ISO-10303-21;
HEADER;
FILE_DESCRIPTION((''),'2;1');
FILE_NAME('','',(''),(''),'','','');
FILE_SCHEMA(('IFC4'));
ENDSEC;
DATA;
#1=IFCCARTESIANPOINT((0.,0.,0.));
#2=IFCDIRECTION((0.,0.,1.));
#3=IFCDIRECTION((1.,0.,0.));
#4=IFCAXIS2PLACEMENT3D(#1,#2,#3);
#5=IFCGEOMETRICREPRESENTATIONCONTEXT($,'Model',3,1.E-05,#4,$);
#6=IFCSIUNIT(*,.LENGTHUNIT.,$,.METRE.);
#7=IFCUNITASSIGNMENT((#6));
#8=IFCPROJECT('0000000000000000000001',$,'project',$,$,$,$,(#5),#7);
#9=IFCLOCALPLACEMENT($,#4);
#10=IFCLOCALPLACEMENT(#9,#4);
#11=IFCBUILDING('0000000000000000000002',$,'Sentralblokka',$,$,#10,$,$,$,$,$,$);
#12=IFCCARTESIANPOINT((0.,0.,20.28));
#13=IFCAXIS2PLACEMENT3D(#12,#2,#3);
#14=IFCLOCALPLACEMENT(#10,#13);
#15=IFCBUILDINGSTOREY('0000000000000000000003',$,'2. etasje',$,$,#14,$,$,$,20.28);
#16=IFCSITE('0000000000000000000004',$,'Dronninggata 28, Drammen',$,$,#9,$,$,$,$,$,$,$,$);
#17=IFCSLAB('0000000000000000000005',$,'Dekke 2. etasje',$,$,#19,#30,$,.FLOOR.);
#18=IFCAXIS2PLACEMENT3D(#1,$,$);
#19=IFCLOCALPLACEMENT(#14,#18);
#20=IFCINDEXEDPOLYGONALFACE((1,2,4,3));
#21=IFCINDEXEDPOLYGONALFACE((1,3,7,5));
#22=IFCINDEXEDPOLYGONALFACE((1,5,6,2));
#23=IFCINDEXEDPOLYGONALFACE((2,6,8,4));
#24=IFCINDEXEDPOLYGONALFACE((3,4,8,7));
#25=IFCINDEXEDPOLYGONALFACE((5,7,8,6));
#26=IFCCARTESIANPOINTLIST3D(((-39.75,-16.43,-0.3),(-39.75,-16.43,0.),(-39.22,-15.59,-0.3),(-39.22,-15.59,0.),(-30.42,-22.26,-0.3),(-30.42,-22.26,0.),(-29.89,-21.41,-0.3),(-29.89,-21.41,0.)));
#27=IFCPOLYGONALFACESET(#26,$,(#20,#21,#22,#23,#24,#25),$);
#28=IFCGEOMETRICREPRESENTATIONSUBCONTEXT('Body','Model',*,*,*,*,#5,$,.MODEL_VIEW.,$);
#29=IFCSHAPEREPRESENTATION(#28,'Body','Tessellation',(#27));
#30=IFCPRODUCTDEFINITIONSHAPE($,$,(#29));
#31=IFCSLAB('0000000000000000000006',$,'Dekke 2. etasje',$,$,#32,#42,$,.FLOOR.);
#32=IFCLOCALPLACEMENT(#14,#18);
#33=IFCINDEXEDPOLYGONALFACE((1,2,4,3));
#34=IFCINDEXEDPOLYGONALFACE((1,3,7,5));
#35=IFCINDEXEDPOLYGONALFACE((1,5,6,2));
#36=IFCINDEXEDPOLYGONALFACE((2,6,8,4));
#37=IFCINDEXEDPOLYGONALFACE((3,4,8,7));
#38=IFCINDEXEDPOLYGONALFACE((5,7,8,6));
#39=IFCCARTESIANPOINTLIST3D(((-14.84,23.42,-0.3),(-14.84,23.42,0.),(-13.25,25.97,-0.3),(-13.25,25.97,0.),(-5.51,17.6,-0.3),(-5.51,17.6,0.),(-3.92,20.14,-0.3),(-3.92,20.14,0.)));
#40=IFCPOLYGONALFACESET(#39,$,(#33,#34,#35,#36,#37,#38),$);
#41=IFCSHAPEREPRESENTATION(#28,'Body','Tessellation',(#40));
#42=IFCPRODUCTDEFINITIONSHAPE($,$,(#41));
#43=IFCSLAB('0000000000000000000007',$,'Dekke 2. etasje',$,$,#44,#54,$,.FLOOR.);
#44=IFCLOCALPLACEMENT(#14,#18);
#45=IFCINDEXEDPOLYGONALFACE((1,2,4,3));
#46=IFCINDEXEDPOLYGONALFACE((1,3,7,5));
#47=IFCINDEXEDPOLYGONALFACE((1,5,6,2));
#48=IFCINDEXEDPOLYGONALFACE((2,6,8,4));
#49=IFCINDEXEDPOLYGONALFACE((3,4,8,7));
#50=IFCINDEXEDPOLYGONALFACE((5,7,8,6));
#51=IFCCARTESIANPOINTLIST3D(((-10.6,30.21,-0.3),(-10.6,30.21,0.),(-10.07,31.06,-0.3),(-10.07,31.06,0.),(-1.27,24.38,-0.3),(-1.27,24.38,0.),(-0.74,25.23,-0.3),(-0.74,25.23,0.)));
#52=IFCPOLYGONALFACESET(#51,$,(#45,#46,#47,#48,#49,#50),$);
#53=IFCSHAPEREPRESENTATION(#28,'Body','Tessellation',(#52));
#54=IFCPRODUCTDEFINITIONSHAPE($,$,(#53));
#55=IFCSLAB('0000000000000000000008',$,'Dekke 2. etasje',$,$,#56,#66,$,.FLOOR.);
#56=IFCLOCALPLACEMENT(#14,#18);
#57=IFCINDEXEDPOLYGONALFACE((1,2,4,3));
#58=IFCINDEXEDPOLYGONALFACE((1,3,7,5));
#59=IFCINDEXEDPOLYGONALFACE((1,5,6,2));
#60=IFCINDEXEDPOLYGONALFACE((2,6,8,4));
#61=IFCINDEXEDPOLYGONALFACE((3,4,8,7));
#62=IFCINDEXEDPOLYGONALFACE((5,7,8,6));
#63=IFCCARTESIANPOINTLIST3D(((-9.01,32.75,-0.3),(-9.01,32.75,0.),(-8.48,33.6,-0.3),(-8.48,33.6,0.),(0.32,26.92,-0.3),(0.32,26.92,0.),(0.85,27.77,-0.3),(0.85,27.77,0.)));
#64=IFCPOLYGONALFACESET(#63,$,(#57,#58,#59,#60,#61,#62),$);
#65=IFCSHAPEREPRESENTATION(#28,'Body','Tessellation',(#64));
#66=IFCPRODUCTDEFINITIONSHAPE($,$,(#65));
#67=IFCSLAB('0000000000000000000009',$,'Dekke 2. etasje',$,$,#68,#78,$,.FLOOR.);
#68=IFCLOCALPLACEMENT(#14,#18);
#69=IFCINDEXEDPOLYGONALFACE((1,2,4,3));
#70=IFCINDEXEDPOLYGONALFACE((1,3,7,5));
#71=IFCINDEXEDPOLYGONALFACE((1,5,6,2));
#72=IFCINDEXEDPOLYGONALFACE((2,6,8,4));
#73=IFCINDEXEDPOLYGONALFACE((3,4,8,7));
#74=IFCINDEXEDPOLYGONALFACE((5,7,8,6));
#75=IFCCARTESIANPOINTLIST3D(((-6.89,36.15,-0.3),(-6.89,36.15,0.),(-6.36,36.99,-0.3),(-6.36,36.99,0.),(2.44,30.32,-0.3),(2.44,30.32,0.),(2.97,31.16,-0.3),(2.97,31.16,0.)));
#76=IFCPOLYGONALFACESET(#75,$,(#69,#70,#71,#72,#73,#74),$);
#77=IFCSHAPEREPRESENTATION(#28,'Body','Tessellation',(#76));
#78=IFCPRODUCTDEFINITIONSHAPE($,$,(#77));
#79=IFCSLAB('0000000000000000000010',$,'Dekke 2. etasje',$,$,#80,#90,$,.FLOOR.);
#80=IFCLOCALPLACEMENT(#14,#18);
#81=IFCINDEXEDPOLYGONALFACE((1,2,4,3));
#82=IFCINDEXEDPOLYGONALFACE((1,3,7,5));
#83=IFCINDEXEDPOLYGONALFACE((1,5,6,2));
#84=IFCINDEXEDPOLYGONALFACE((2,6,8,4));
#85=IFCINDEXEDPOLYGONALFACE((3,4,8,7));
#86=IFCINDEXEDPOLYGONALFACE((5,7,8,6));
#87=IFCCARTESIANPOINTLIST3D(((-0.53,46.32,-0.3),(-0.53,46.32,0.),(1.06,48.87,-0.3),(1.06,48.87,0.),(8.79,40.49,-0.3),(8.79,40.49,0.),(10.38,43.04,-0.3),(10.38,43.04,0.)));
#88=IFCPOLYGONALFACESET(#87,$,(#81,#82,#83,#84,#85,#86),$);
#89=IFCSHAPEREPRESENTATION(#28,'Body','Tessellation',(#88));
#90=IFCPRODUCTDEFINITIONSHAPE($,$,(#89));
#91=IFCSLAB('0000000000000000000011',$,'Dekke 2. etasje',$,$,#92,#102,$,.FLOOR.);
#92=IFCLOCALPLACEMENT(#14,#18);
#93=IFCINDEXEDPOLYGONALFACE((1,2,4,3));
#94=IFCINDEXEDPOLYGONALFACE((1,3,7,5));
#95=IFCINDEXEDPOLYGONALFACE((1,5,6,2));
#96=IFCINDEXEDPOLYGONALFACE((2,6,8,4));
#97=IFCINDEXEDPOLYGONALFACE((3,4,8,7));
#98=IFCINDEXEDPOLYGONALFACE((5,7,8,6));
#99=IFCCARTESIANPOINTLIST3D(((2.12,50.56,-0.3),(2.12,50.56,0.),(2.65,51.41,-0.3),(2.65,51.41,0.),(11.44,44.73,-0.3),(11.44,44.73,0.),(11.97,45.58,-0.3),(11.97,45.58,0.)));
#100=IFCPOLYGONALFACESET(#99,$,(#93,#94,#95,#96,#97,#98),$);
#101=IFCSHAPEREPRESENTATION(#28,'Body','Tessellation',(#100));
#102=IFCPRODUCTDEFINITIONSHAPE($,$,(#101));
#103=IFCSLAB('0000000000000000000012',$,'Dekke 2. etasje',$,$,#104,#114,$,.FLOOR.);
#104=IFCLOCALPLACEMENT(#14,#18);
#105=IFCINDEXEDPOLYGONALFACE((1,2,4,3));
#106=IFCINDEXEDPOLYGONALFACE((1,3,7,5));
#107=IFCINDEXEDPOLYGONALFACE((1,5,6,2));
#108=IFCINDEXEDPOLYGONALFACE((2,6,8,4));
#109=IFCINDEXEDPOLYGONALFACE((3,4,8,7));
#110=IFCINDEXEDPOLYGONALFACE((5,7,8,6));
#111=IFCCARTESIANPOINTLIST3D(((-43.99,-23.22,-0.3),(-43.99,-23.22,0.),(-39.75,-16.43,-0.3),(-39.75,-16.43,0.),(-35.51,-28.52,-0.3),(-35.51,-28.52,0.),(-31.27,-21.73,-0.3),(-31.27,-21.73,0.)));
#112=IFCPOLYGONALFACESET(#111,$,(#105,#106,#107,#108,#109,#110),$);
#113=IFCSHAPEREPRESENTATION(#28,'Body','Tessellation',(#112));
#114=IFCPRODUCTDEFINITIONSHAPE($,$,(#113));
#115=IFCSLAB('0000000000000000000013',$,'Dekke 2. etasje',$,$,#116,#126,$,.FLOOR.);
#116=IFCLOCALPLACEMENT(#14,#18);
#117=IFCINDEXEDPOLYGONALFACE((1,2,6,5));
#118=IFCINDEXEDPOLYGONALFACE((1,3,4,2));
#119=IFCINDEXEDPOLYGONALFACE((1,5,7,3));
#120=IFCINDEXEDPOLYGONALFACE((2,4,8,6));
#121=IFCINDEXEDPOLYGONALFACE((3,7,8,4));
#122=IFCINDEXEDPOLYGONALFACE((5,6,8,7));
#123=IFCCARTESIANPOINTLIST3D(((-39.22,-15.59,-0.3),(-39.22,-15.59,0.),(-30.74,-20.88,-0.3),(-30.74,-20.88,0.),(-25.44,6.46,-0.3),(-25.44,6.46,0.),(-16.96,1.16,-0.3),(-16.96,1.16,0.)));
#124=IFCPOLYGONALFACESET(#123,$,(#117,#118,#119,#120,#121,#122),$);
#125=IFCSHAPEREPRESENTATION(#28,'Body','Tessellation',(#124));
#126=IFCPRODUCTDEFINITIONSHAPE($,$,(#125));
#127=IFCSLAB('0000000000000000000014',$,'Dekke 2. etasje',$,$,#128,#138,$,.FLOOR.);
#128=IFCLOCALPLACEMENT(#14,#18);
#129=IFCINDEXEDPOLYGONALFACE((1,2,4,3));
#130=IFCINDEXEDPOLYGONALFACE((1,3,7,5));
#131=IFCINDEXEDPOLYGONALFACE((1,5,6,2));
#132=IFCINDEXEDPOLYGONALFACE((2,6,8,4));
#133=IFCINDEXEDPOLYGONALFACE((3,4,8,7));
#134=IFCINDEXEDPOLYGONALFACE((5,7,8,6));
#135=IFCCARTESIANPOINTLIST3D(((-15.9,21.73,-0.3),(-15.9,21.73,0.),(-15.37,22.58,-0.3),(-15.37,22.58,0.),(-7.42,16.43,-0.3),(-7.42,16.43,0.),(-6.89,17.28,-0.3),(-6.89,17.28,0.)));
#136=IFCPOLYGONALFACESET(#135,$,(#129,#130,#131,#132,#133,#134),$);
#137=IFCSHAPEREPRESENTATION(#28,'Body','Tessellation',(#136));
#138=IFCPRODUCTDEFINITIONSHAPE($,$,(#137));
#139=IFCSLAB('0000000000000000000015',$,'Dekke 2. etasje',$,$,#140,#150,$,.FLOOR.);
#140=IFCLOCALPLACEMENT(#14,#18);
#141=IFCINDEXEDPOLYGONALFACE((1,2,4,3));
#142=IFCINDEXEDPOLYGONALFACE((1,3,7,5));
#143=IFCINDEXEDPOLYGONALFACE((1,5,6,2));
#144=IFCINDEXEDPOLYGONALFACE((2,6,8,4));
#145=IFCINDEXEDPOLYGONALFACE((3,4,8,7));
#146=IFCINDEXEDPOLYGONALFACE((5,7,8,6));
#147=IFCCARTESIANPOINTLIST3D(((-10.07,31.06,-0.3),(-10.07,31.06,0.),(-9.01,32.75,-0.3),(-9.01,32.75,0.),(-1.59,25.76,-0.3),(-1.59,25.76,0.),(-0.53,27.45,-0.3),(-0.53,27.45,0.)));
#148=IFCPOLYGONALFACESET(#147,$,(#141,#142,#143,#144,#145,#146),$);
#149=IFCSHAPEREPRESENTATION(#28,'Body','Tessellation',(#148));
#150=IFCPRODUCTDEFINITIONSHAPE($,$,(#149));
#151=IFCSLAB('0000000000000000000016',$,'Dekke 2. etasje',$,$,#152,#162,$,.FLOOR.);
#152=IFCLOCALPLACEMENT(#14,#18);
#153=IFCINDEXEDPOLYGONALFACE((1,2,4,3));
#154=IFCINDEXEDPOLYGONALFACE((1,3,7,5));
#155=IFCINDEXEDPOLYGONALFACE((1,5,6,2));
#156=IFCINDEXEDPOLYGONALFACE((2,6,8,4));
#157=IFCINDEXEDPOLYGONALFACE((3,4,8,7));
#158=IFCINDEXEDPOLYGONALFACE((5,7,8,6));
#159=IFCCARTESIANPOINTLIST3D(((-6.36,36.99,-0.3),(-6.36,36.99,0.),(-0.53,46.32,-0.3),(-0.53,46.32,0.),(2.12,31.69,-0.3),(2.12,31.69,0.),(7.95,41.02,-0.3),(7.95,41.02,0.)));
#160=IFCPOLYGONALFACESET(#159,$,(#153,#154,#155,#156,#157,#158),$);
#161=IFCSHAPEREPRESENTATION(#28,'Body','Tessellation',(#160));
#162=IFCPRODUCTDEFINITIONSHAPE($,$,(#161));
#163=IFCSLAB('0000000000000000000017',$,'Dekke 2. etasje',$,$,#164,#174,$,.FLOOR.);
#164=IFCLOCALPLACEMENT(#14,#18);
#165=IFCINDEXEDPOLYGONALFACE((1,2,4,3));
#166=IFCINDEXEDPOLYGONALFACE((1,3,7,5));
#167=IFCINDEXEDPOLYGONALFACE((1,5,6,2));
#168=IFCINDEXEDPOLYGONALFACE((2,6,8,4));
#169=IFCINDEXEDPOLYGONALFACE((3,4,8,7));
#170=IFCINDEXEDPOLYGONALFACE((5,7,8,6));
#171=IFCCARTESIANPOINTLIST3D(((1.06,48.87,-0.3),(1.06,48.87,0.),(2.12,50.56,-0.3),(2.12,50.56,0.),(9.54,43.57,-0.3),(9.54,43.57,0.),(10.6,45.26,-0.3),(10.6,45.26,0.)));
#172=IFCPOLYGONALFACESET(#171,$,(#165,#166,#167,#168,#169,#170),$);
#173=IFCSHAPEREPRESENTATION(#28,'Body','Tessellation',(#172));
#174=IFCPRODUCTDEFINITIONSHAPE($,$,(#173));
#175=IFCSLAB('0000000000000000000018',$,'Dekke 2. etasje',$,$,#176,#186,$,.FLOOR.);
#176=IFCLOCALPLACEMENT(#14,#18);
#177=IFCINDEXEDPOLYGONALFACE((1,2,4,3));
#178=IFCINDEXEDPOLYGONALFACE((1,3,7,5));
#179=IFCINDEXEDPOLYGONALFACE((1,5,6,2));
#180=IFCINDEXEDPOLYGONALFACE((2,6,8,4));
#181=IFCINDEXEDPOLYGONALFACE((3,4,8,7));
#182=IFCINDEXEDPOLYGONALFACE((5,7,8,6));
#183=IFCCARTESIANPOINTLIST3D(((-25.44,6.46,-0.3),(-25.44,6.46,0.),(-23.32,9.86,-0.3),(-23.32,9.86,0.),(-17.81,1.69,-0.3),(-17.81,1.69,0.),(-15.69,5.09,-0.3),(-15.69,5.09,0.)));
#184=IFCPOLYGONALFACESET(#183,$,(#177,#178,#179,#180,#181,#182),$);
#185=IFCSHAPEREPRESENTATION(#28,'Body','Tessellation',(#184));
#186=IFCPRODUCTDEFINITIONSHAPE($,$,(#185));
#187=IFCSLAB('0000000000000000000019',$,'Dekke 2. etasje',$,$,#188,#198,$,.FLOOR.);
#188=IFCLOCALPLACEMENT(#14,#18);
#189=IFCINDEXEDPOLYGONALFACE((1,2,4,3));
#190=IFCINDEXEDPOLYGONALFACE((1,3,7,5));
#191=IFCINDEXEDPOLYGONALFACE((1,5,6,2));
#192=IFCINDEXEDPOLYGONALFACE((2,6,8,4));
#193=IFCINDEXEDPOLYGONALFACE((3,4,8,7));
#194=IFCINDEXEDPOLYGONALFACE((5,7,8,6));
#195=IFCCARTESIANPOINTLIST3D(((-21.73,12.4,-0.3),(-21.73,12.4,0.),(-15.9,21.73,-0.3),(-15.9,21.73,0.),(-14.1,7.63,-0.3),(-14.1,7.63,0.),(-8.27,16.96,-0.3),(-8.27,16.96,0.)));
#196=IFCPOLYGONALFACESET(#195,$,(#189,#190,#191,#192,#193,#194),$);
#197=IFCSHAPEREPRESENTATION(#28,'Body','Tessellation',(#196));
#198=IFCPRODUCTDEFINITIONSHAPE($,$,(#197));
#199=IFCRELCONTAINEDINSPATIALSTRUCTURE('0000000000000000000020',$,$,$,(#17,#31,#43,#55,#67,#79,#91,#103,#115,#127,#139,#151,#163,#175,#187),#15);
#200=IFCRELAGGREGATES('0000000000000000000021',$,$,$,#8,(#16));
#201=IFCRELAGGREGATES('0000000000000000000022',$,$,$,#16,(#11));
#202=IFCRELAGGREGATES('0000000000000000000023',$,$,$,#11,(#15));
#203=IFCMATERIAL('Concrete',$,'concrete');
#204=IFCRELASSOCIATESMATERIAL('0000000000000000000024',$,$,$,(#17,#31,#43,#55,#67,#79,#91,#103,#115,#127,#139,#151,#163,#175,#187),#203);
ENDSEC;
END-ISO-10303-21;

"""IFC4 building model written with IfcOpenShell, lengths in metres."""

from ifc_helpers import new_model, si_unit, frame, origin_with_axes, place, context, subcontext, project, spatial, polyline, outline, extrude, material, element, save


model = new_model("IFC4")

# Units and contexts
model_context = context("Model", 3, precision=1e-05, world=origin_with_axes())
body_context = subcontext(model_context, "Body", "Model", "MODEL_VIEW")
ifc_project = project(units=[si_unit("LENGTHUNIT", "METRE")], contexts=[model_context])

# Site, building, storey
site_placement = place(None, origin_with_axes())
site = spatial("IfcSite", under=ifc_project, at=site_placement, Name="Dronninggata 28, Drammen")
building_placement = place(site_placement, origin_with_axes())
building = spatial("IfcBuilding", under=site, at=building_placement, Name="Sentralblokka")
storey_placement = place(building_placement, frame((0.0, 0.0, 20.28), z_axis=(0.0, 0.0, 1.0), x_axis=(1.0, 0.0, 0.0)))
storey = spatial("IfcBuildingStorey", under=building, at=storey_placement, Name="2. etasje", Elevation=20.28)

# Slabs
ifc_material = material(Name="Concrete", Category="concrete")
slab_1_placement = place(storey_placement, frame((0.0, 0.0, -20.28), z_axis=(0.0, 0.0, 1.0), x_axis=(1.0, 0.0, 0.0)))
element("IfcSlab", 1, at=slab_1_placement, inside=storey, material=ifc_material, Name="Dekke 2. etasje", PredefinedType="FLOOR", context=body_context, shape_type="SweptSolid", body=[
    extrude(outline(polyline([(-30.42, -22.26), (-29.89, -21.41), (-39.22, -15.59), (-39.75, -16.43), (-30.42, -22.26)])), frame((0.0, 0.0, 19.98)), (0.0, 0.0, 1.0), 0.3),
])
slab_2_placement = place(storey_placement, frame((0.0, 0.0, -20.28), z_axis=(0.0, 0.0, 1.0), x_axis=(1.0, 0.0, 0.0)))
element("IfcSlab", 2, at=slab_2_placement, inside=storey, material=ifc_material, Name="Dekke 2. etasje", PredefinedType="FLOOR", context=body_context, shape_type="SweptSolid", body=[
    extrude(outline(polyline([(-5.51, 17.6), (-3.92, 20.14), (-13.25, 25.97), (-14.84, 23.42), (-5.51, 17.6)])), frame((0.0, 0.0, 19.98)), (0.0, 0.0, 1.0), 0.3),
])
slab_3_placement = place(storey_placement, frame((0.0, 0.0, -20.28), z_axis=(0.0, 0.0, 1.0), x_axis=(1.0, 0.0, 0.0)))
element("IfcSlab", 3, at=slab_3_placement, inside=storey, material=ifc_material, Name="Dekke 2. etasje", PredefinedType="FLOOR", context=body_context, shape_type="SweptSolid", body=[
    extrude(outline(polyline([(-1.27, 24.38), (-0.74, 25.23), (-10.07, 31.06), (-10.6, 30.21), (-1.27, 24.38)])), frame((0.0, 0.0, 19.98)), (0.0, 0.0, 1.0), 0.3),
])
slab_4_placement = place(storey_placement, frame((0.0, 0.0, -20.28), z_axis=(0.0, 0.0, 1.0), x_axis=(1.0, 0.0, 0.0)))
element("IfcSlab", 4, at=slab_4_placement, inside=storey, material=ifc_material, Name="Dekke 2. etasje", PredefinedType="FLOOR", context=body_context, shape_type="SweptSolid", body=[
    extrude(outline(polyline([(0.32, 26.92), (0.85, 27.77), (-8.48, 33.6), (-9.01, 32.75), (0.32, 26.92)])), frame((0.0, 0.0, 19.98)), (0.0, 0.0, 1.0), 0.3),
])
slab_5_placement = place(storey_placement, frame((0.0, 0.0, -20.28), z_axis=(0.0, 0.0, 1.0), x_axis=(1.0, 0.0, 0.0)))
element("IfcSlab", 5, at=slab_5_placement, inside=storey, material=ifc_material, Name="Dekke 2. etasje", PredefinedType="FLOOR", context=body_context, shape_type="SweptSolid", body=[
    extrude(outline(polyline([(2.44, 30.32), (2.97, 31.16), (-6.36, 36.99), (-6.89, 36.15), (2.44, 30.32)])), frame((0.0, 0.0, 19.98)), (0.0, 0.0, 1.0), 0.3),
])
slab_6_placement = place(storey_placement, frame((0.0, 0.0, -20.28), z_axis=(0.0, 0.0, 1.0), x_axis=(1.0, 0.0, 0.0)))
element("IfcSlab", 6, at=slab_6_placement, inside=storey, material=ifc_material, Name="Dekke 2. etasje", PredefinedType="FLOOR", context=body_context, shape_type="SweptSolid", body=[
    extrude(outline(polyline([(8.79, 40.49), (10.38, 43.04), (1.06, 48.87), (-0.53, 46.32), (8.79, 40.49)])), frame((0.0, 0.0, 19.98)), (0.0, 0.0, 1.0), 0.3),
])
slab_7_placement = place(storey_placement, frame((0.0, 0.0, -20.28), z_axis=(0.0, 0.0, 1.0), x_axis=(1.0, 0.0, 0.0)))
element("IfcSlab", 7, at=slab_7_placement, inside=storey, material=ifc_material, Name="Dekke 2. etasje", PredefinedType="FLOOR", context=body_context, shape_type="SweptSolid", body=[
    extrude(outline(polyline([(11.44, 44.73), (11.97, 45.58), (2.65, 51.41), (2.12, 50.56), (11.44, 44.73)])), frame((0.0, 0.0, 19.98)), (0.0, 0.0, 1.0), 0.3),
])
slab_8_placement = place(storey_placement, frame((0.0, 0.0, -20.28), z_axis=(0.0, 0.0, 1.0), x_axis=(1.0, 0.0, 0.0)))
element("IfcSlab", 8, at=slab_8_placement, inside=storey, material=ifc_material, Name="Dekke 2. etasje", PredefinedType="FLOOR", context=body_context, shape_type="SweptSolid", body=[
    extrude(outline(polyline([(-35.51, -28.52), (-31.27, -21.73), (-39.75, -16.43), (-43.99, -23.22), (-35.51, -28.52)])), frame((0.0, 0.0, 19.98)), (0.0, 0.0, 1.0), 0.3),
])
slab_9_placement = place(storey_placement, frame((0.0, 0.0, -20.28), z_axis=(0.0, 0.0, 1.0), x_axis=(1.0, 0.0, 0.0)))
element("IfcSlab", 9, at=slab_9_placement, inside=storey, material=ifc_material, Name="Dekke 2. etasje", PredefinedType="FLOOR", context=body_context, shape_type="SweptSolid", body=[
    extrude(outline(polyline([(-30.74, -20.88), (-16.96, 1.16), (-25.44, 6.46), (-39.22, -15.59), (-30.74, -20.88)])), frame((0.0, 0.0, 19.98)), (0.0, 0.0, 1.0), 0.3),
])
slab_10_placement = place(storey_placement, frame((0.0, 0.0, -20.28), z_axis=(0.0, 0.0, 1.0), x_axis=(1.0, 0.0, 0.0)))
element("IfcSlab", 10, at=slab_10_placement, inside=storey, material=ifc_material, Name="Dekke 2. etasje", PredefinedType="FLOOR", context=body_context, shape_type="SweptSolid", body=[
    extrude(outline(polyline([(-7.42, 16.43), (-6.89, 17.28), (-15.37, 22.58), (-15.9, 21.73), (-7.42, 16.43)])), frame((0.0, 0.0, 19.98)), (0.0, 0.0, 1.0), 0.3),
])
slab_11_placement = place(storey_placement, frame((0.0, 0.0, -20.28), z_axis=(0.0, 0.0, 1.0), x_axis=(1.0, 0.0, 0.0)))
element("IfcSlab", 11, at=slab_11_placement, inside=storey, material=ifc_material, Name="Dekke 2. etasje", PredefinedType="FLOOR", context=body_context, shape_type="SweptSolid", body=[
    extrude(outline(polyline([(-1.59, 25.76), (-0.53, 27.45), (-9.01, 32.75), (-10.07, 31.06), (-1.59, 25.76)])), frame((0.0, 0.0, 19.98)), (0.0, 0.0, 1.0), 0.3),
])
slab_12_placement = place(storey_placement, frame((0.0, 0.0, -20.28), z_axis=(0.0, 0.0, 1.0), x_axis=(1.0, 0.0, 0.0)))
element("IfcSlab", 12, at=slab_12_placement, inside=storey, material=ifc_material, Name="Dekke 2. etasje", PredefinedType="FLOOR", context=body_context, shape_type="SweptSolid", body=[
    extrude(outline(polyline([(2.12, 31.69), (7.95, 41.02), (-0.53, 46.32), (-6.36, 36.99), (2.12, 31.69)])), frame((0.0, 0.0, 19.98)), (0.0, 0.0, 1.0), 0.3),
])
slab_13_placement = place(storey_placement, frame((0.0, 0.0, -20.28), z_axis=(0.0, 0.0, 1.0), x_axis=(1.0, 0.0, 0.0)))
element("IfcSlab", 13, at=slab_13_placement, inside=storey, material=ifc_material, Name="Dekke 2. etasje", PredefinedType="FLOOR", context=body_context, shape_type="SweptSolid", body=[
    extrude(outline(polyline([(9.54, 43.57), (10.6, 45.26), (2.12, 50.56), (1.06, 48.87), (9.54, 43.57)])), frame((0.0, 0.0, 19.98)), (0.0, 0.0, 1.0), 0.3),
])
slab_14_placement = place(storey_placement, frame((0.0, 0.0, -20.28), z_axis=(0.0, 0.0, 1.0), x_axis=(1.0, 0.0, 0.0)))
element("IfcSlab", 14, at=slab_14_placement, inside=storey, material=ifc_material, Name="Dekke 2. etasje", PredefinedType="FLOOR", context=body_context, shape_type="SweptSolid", body=[
    extrude(outline(polyline([(-17.81, 1.69), (-15.69, 5.09), (-23.32, 9.86), (-25.44, 6.46), (-17.81, 1.69)])), frame((0.0, 0.0, 19.98)), (0.0, 0.0, 1.0), 0.3),
])
slab_15_placement = place(storey_placement, frame((0.0, 0.0, -20.28), z_axis=(0.0, 0.0, 1.0), x_axis=(1.0, 0.0, 0.0)))
element("IfcSlab", 15, at=slab_15_placement, inside=storey, material=ifc_material, Name="Dekke 2. etasje", PredefinedType="FLOOR", context=body_context, shape_type="SweptSolid", body=[
    extrude(outline(polyline([(-14.1, 7.63), (-8.27, 16.96), (-15.9, 21.73), (-21.73, 12.4), (-14.1, 7.63)])), frame((0.0, 0.0, 19.98)), (0.0, 0.0, 1.0), 0.3),
])

save(model, "model.ifc")
